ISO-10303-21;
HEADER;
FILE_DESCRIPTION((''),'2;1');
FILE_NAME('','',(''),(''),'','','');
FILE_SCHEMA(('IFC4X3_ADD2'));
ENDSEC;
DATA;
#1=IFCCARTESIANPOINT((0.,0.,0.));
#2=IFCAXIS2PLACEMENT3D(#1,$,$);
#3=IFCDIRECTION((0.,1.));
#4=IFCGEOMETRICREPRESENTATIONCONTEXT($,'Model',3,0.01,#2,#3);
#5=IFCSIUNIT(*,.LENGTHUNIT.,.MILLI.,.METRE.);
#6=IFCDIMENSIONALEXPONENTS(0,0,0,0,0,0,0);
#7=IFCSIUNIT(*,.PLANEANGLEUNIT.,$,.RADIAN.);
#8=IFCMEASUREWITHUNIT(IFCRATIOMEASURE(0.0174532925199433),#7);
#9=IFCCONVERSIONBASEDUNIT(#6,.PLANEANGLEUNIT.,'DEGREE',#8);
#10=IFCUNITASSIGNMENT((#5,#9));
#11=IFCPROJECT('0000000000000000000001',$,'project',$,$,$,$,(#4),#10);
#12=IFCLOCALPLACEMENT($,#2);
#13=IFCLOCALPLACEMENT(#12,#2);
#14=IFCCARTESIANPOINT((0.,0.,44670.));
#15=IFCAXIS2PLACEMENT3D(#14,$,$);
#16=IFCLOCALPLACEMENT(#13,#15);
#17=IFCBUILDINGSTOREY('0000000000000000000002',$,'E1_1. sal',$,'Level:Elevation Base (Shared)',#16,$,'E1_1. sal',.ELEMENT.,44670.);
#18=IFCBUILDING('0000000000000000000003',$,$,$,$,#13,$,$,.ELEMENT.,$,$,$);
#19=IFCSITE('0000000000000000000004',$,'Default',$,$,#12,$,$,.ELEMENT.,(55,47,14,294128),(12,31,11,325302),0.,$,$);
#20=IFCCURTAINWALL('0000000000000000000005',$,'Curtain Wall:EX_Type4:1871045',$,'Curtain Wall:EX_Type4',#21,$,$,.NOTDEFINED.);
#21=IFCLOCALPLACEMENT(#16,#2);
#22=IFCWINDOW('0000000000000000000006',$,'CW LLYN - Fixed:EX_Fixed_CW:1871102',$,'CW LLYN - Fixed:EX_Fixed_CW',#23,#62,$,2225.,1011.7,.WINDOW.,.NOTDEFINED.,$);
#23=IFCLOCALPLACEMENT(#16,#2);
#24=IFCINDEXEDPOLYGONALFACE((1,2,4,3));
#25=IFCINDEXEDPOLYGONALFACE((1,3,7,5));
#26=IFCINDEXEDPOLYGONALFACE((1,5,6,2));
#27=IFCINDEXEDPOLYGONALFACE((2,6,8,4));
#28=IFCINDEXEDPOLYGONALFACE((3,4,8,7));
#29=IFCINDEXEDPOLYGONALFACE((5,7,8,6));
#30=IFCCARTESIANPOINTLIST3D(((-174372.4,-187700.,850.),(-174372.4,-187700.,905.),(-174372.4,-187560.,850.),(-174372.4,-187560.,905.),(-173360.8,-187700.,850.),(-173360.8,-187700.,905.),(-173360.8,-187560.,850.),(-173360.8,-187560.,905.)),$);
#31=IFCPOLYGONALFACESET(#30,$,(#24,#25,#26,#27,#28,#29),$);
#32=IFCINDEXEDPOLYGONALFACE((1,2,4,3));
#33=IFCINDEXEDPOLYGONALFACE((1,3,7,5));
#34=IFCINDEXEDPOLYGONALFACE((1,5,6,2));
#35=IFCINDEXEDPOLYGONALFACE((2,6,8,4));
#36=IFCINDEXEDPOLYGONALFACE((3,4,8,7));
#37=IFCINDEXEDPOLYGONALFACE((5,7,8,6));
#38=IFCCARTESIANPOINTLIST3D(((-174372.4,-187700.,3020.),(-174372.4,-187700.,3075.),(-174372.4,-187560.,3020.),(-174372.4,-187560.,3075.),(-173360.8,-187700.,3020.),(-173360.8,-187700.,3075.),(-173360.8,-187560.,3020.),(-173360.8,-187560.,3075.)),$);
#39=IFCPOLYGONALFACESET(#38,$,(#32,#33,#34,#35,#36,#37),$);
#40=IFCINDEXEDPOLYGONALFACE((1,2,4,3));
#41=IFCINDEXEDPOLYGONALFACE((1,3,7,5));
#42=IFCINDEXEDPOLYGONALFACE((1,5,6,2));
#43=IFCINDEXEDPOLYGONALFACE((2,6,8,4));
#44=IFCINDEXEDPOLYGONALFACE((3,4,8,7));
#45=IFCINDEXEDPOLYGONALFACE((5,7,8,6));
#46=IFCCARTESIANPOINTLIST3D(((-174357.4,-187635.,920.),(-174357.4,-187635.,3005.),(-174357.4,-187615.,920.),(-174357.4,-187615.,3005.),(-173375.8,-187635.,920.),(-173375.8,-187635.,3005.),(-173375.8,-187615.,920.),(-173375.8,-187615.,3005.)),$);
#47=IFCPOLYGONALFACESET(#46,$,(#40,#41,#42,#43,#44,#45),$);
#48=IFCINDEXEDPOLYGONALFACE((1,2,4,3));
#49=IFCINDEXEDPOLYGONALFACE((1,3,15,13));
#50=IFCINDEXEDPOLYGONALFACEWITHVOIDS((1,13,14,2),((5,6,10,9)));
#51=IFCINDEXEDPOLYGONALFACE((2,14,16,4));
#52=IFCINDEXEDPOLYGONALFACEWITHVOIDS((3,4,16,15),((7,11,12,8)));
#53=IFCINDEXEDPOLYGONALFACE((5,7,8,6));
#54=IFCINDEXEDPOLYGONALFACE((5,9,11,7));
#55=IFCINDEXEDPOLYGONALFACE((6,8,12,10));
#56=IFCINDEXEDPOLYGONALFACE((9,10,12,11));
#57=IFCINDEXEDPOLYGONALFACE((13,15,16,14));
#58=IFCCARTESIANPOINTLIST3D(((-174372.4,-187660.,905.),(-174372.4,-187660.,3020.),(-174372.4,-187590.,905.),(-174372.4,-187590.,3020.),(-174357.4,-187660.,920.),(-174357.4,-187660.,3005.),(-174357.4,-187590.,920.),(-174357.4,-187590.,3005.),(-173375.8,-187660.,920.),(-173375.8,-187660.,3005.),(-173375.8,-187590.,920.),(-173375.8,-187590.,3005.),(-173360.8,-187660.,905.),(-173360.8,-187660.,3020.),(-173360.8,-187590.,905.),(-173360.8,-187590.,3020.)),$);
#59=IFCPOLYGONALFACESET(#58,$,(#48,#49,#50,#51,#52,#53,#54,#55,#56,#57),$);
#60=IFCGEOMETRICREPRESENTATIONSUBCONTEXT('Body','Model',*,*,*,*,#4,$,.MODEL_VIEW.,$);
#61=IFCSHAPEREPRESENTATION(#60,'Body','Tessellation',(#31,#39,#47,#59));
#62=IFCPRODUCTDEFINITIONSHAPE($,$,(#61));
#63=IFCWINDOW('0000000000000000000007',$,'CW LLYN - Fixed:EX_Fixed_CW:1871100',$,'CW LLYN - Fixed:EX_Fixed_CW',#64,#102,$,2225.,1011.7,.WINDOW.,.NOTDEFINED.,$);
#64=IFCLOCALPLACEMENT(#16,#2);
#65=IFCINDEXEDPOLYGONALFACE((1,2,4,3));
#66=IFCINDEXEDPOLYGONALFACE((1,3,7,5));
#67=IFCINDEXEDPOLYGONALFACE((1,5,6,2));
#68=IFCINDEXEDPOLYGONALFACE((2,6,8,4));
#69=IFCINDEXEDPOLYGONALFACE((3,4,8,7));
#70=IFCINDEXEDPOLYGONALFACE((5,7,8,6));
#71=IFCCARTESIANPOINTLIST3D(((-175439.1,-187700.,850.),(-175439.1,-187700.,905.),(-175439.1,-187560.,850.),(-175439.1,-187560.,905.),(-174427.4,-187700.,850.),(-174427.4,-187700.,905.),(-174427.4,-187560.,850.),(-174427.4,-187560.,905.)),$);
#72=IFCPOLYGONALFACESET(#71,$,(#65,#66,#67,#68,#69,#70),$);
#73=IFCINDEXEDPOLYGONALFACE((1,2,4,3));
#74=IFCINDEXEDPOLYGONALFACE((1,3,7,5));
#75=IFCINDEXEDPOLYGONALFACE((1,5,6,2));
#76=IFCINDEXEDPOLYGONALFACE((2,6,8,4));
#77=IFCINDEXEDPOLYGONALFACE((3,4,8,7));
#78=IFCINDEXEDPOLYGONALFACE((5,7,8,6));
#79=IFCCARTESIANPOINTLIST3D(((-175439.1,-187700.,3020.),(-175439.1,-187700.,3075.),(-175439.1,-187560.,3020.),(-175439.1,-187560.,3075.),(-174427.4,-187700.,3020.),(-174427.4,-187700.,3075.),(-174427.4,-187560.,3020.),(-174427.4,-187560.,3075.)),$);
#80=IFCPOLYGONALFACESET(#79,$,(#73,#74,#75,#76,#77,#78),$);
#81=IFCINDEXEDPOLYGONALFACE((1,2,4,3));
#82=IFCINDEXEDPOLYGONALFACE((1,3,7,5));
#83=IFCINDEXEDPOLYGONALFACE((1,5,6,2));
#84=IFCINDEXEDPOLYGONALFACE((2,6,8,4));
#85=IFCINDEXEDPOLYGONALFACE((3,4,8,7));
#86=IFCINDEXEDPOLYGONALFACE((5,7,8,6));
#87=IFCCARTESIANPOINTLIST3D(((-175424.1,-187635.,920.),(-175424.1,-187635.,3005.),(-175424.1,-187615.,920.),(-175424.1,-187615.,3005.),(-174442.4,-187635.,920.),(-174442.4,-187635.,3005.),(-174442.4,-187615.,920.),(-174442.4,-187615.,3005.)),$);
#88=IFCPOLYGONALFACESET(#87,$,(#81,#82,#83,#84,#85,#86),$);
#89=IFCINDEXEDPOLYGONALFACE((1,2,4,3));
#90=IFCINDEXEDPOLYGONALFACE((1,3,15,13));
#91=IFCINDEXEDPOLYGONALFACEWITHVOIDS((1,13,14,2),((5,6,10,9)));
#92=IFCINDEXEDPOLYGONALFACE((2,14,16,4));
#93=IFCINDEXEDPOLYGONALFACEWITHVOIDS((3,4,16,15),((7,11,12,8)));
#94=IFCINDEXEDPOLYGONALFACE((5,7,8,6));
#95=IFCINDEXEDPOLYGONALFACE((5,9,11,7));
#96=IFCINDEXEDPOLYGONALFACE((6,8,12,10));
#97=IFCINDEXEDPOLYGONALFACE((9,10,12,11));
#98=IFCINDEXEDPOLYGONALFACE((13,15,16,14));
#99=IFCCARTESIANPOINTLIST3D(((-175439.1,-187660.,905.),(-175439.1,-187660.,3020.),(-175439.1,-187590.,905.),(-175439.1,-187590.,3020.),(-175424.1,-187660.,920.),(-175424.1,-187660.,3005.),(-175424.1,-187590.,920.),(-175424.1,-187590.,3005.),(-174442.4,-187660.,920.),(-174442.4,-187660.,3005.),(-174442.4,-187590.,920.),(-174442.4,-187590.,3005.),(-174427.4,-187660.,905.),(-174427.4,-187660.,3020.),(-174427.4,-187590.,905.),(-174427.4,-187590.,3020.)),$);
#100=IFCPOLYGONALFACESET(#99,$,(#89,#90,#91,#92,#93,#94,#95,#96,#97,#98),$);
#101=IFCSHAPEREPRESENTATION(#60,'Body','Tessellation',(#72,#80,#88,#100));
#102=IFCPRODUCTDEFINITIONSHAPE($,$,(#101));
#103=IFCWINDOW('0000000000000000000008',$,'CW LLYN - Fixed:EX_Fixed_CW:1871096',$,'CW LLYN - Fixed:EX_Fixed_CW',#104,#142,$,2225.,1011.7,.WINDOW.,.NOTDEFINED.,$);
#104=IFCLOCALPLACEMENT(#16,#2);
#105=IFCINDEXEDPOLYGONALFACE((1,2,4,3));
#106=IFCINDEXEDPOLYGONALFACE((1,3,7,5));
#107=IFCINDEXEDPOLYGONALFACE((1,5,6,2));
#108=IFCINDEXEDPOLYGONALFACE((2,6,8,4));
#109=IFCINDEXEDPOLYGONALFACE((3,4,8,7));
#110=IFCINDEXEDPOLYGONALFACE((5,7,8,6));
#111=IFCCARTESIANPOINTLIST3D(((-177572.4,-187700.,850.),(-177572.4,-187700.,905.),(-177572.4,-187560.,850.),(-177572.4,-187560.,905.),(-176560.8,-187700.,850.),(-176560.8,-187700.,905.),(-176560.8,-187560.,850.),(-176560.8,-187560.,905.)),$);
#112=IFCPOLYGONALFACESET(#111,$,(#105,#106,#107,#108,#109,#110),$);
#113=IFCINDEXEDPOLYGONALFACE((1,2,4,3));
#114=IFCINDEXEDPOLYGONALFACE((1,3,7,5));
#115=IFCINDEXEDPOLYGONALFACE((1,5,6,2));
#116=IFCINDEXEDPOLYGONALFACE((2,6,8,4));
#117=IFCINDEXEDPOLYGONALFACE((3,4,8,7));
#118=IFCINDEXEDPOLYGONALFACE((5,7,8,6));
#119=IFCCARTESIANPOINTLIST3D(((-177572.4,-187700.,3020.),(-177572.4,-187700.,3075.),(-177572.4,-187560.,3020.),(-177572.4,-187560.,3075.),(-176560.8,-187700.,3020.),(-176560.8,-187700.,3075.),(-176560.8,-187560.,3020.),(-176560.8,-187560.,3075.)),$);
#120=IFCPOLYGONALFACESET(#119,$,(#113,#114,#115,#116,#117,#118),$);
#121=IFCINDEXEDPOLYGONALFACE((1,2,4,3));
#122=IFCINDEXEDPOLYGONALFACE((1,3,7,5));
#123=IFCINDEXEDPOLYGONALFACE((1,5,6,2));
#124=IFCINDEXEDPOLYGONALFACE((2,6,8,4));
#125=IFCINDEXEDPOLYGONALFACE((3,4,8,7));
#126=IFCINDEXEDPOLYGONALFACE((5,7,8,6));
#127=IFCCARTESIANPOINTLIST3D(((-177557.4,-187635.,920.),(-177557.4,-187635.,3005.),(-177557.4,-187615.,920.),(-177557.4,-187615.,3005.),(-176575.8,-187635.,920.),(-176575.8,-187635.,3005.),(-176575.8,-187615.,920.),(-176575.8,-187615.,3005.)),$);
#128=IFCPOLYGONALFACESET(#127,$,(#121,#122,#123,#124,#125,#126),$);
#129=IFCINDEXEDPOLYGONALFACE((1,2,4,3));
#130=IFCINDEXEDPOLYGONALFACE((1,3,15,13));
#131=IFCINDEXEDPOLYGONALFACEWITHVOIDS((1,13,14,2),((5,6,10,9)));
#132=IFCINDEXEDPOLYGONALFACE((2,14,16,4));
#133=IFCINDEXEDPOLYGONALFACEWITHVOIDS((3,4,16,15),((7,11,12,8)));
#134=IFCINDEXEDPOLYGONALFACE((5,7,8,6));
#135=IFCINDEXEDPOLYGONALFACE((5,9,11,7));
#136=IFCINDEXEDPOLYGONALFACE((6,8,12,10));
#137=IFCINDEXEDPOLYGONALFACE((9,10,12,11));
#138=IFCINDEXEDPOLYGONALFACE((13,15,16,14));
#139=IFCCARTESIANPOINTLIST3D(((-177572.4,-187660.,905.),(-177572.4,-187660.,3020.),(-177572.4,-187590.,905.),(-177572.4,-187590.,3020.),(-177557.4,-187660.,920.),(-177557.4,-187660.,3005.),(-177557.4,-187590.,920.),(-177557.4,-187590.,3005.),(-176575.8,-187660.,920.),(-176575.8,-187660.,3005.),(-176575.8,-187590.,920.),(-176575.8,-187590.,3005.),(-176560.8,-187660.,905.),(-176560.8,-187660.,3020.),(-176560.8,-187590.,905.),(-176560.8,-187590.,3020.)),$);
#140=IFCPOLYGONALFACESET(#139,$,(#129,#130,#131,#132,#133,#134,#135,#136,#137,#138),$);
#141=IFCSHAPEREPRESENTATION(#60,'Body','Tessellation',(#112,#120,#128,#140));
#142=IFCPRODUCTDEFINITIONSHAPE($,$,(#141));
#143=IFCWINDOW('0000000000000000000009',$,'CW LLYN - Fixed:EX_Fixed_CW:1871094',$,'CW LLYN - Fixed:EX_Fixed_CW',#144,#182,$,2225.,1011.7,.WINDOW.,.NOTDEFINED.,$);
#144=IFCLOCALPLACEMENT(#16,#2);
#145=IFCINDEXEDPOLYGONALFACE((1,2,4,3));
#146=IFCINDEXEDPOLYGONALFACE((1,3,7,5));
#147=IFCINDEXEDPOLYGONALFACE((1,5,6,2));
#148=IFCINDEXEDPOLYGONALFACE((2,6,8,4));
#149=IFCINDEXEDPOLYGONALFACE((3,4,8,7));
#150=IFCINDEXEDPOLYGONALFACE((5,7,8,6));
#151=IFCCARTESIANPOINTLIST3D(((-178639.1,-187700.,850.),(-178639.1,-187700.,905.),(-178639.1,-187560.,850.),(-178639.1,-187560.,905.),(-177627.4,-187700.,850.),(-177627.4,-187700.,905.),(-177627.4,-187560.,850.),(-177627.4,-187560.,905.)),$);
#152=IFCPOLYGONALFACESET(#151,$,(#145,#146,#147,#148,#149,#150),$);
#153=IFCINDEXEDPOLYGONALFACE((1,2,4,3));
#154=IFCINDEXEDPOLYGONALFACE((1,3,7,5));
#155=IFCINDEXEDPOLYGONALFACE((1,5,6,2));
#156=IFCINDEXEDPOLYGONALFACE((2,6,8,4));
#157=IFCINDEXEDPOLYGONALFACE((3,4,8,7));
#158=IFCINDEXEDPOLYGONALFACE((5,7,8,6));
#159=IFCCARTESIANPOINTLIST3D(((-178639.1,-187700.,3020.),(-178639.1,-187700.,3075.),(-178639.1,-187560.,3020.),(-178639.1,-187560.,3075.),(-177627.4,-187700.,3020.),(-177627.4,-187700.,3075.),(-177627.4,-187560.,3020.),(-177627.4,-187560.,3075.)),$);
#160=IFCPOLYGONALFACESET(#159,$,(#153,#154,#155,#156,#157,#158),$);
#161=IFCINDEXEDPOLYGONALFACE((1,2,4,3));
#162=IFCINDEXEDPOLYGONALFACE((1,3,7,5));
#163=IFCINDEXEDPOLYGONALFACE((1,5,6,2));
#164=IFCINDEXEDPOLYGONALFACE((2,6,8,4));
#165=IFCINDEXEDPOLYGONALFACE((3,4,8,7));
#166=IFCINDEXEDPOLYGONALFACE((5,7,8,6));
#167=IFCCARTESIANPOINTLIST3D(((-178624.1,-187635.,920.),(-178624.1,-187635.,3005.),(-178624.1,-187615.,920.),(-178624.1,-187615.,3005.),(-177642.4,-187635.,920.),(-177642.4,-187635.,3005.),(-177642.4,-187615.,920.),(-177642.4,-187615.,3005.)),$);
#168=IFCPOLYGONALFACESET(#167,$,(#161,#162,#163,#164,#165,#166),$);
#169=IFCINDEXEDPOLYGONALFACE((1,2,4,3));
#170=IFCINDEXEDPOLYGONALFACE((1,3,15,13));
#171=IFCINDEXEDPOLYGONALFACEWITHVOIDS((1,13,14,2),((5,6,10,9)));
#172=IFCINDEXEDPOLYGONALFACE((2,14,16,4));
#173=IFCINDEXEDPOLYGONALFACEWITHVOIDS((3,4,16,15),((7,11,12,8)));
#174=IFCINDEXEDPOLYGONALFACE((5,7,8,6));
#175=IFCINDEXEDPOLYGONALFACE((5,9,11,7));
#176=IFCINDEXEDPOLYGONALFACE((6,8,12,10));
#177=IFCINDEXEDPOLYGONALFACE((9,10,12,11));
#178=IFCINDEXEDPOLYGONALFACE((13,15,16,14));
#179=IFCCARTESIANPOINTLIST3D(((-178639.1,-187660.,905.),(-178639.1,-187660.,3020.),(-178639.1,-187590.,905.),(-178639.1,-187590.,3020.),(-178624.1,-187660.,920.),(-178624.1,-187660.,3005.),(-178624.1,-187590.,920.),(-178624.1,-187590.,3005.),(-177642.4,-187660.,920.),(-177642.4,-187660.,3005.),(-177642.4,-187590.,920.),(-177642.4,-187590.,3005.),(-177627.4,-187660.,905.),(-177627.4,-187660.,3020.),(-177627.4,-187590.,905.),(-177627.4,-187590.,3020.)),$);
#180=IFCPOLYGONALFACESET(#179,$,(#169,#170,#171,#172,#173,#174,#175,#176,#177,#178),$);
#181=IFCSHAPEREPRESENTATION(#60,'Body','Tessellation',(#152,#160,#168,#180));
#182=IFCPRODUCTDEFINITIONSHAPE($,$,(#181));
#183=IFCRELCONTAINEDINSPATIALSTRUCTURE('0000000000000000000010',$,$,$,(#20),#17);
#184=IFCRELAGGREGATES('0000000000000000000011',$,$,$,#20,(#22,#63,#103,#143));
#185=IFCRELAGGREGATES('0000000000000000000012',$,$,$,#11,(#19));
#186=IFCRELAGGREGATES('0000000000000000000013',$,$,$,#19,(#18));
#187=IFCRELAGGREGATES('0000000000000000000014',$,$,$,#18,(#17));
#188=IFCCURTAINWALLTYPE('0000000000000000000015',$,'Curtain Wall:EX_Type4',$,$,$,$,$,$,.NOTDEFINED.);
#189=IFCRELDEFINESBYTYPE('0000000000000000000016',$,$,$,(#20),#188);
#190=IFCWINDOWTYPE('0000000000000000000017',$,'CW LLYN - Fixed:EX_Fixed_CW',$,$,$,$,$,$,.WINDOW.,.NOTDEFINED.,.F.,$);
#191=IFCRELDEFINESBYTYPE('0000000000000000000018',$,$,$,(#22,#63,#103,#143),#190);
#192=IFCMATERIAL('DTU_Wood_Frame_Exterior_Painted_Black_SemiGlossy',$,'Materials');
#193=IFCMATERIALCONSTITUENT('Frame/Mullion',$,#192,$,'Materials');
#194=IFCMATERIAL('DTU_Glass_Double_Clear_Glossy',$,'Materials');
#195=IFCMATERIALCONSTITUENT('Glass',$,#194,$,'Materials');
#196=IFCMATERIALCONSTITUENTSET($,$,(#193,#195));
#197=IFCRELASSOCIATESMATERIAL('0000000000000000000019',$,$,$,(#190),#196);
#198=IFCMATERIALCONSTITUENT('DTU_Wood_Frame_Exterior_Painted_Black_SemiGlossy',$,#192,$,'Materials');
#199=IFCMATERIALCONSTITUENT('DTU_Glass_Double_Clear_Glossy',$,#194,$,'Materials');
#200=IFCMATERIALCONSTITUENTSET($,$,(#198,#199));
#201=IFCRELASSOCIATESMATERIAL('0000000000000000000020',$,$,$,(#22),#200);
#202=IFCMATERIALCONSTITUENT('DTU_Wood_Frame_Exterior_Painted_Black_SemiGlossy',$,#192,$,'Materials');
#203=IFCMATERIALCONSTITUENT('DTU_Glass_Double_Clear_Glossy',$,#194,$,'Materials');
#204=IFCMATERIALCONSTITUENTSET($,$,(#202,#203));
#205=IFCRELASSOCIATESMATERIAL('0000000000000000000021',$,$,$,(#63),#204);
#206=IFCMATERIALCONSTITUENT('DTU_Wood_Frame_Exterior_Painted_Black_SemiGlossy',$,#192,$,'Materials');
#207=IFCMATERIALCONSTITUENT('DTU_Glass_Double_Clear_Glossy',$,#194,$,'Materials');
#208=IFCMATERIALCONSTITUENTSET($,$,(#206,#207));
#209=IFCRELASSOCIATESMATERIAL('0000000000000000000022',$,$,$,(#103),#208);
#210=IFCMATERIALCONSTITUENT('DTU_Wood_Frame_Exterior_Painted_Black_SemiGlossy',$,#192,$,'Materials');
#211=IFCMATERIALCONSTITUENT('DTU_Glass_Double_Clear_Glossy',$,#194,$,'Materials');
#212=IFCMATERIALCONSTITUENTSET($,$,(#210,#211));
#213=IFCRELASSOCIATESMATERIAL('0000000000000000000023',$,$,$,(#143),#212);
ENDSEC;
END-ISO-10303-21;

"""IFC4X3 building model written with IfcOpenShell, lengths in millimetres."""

from ifc_helpers import new_model, entity, si_unit, converted_unit, direction, frame, frame_2d, origin, origin_2d_with_axis, place, context, subcontext, project, spatial, polyline, rectangle, outline, extrude, source, transform, mapped, material, constituent, constituent_set, type_object, type_shapes, element, aggregate, save


model = new_model("IFC4X3")

# Units and contexts
model_context = context("Model", 3, precision=0.01, world=origin(), true_north=direction((0.0, 1.0)))
body_context = subcontext(model_context, "Body", "Model", "MODEL_VIEW")
ifc_project = project(units=[si_unit("LENGTHUNIT", "METRE", prefix="MILLI"), converted_unit("PLANEANGLEUNIT", "DEGREE", entity("IfcRatioMeasure", 0.0174532925199433), si_unit("PLANEANGLEUNIT", "RADIAN"), dimensions=[0, 0, 0, 0, 0, 0, 0])], contexts=[model_context])

# Site, building, storey
site_placement = place(None, origin())
site = spatial("IfcSite", under=ifc_project, at=site_placement, Name="Default", CompositionType="ELEMENT", RefLatitude=(55, 47, 14, 294128), RefLongitude=(12, 31, 11, 325302), RefElevation=0.0)
building_placement = place(site_placement, origin())
building = spatial("IfcBuilding", under=site, at=building_placement, CompositionType="ELEMENT")
storey_placement = place(building_placement, frame((0.0, 0.0, 44670.0)))
storey = spatial("IfcBuildingStorey", under=building, at=storey_placement, Name="E1_1. sal", ObjectType="Level:Elevation Base (Shared)", LongName="E1_1. sal", CompositionType="ELEMENT", Elevation=44670.0)

# Curtain wall
curtain_wall_type_1 = type_object("IfcCurtainWallType", Name="Curtain Wall:EX_Type4", PredefinedType="NOTDEFINED")
curtain_wall_1_placement = place(storey_placement, frame((0.0, 0.0, -44670.0)))
curtain_wall_1 = element("IfcCurtainWall", 1, at=curtain_wall_1_placement, inside=storey, type_object=curtain_wall_type_1, Name="Curtain Wall:EX_Type4:1871045", ObjectType="Curtain Wall:EX_Type4", PredefinedType="NOTDEFINED")

# Windows
ifc_material_1 = material(Name="DTU_Wood_Frame_Exterior_Painted_Black_SemiGlossy", Category="Materials")
ifc_constituent_1 = constituent(ifc_material_1, Name="DTU_Wood_Frame_Exterior_Painted_Black_SemiGlossy", Category="Materials")
ifc_material_2 = material(Name="DTU_Glass_Double_Clear_Glossy", Category="Materials")
ifc_constituent_2 = constituent(ifc_material_2, Name="DTU_Glass_Double_Clear_Glossy", Category="Materials")
ifc_constituent_set_1 = constituent_set(constituents=[ifc_constituent_1, ifc_constituent_2])
ifc_constituent_3 = constituent(ifc_material_1, Name="Frame/Mullion", Category="Materials")
ifc_constituent_4 = constituent(ifc_material_2, Name="Glass", Category="Materials")
ifc_constituent_set_2 = constituent_set(constituents=[ifc_constituent_3, ifc_constituent_4])
window_type_1 = type_object("IfcWindowType", Name="CW LLYN - Fixed:EX_Fixed_CW", ParameterTakesPrecedence=False, PartitioningType="NOTDEFINED", PredefinedType="WINDOW", material=ifc_constituent_set_2)
shared_shape_1 = source(origin(), body_context, "Body", "SweptSolid", [
    extrude(rectangle(XDim=140.0, YDim=1011.7, at=origin_2d_with_axis()), frame((0.0, -130.0, 0.0), z_axis=(0.0, 0.0, 1.0), x_axis=(0.0, -1.0, 0.0)), (0.0, 0.0, 1.0), 55.0),
    extrude(rectangle(XDim=140.0, YDim=1011.7, at=frame_2d((0.0, 0.0), x_axis=(1.0, 0.0))), frame((0.0, -130.0, 2170.0), z_axis=(0.0, 0.0, 1.0), x_axis=(0.0, -1.0, 0.0)), (0.0, 0.0, 1.0), 55.0),
    extrude(rectangle(XDim=981.7, YDim=20.0, at=frame_2d((0.0, 0.0), x_axis=(1.0, 0.0))), frame((0.0, -125.0, 70.0), z_axis=(0.0, 0.0, 1.0), x_axis=(-1.0, 0.0, 0.0)), (0.0, 0.0, 1.0), 2085.0),
    extrude(outline(polyline([(-1057.5, -505.8), (1057.5, -505.8), (1057.5, 505.8), (-1057.5, 505.8), (-1057.5, -505.8)]), holes=[polyline([(-1042.5, 490.8), (1042.5, 490.8), (1042.5, -490.8), (-1042.5, -490.8), (-1042.5, 490.8)])]), frame((0.0, -90.0, 1112.5), z_axis=(0.0, -1.0, 0.0), x_axis=(0.0, 0.0, 1.0)), (0.0, 0.0, 1.0), 70.0),
])
type_shapes(window_type_1, [shared_shape_1])
window_1_placement = place(curtain_wall_1_placement, frame((-173866.6, -187500.0, 45520.0)))
window_1 = element("IfcWindow", 2, at=window_1_placement, type_object=window_type_1, material=ifc_constituent_set_1, Name="CW LLYN - Fixed:EX_Fixed_CW:1871102", ObjectType="CW LLYN - Fixed:EX_Fixed_CW", OverallHeight=2225.0, OverallWidth=1011.7, PartitioningType="NOTDEFINED", PredefinedType="WINDOW", context=body_context, shape_type="MappedRepresentation", body=[
    mapped(shared_shape_1, transform((0.0, 0.0, 0.0), scale=1.0)),
])
ifc_constituent_5 = constituent(ifc_material_1, Name="DTU_Wood_Frame_Exterior_Painted_Black_SemiGlossy", Category="Materials")
ifc_constituent_6 = constituent(ifc_material_2, Name="DTU_Glass_Double_Clear_Glossy", Category="Materials")
ifc_constituent_set_3 = constituent_set(constituents=[ifc_constituent_5, ifc_constituent_6])
window_2_placement = place(curtain_wall_1_placement, frame((-174933.3, -187500.0, 45520.0)))
window_2 = element("IfcWindow", 3, at=window_2_placement, type_object=window_type_1, material=ifc_constituent_set_3, Name="CW LLYN - Fixed:EX_Fixed_CW:1871100", ObjectType="CW LLYN - Fixed:EX_Fixed_CW", OverallHeight=2225.0, OverallWidth=1011.7, PartitioningType="NOTDEFINED", PredefinedType="WINDOW", context=body_context, shape_type="MappedRepresentation", body=[
    mapped(shared_shape_1, transform((0.0, 0.0, 0.0), scale=1.0)),
])
ifc_constituent_7 = constituent(ifc_material_1, Name="DTU_Wood_Frame_Exterior_Painted_Black_SemiGlossy", Category="Materials")
ifc_constituent_8 = constituent(ifc_material_2, Name="DTU_Glass_Double_Clear_Glossy", Category="Materials")
ifc_constituent_set_4 = constituent_set(constituents=[ifc_constituent_7, ifc_constituent_8])
window_3_placement = place(curtain_wall_1_placement, frame((-177066.6, -187500.0, 45520.0)))
window_3 = element("IfcWindow", 4, at=window_3_placement, type_object=window_type_1, material=ifc_constituent_set_4, Name="CW LLYN - Fixed:EX_Fixed_CW:1871096", ObjectType="CW LLYN - Fixed:EX_Fixed_CW", OverallHeight=2225.0, OverallWidth=1011.7, PartitioningType="NOTDEFINED", PredefinedType="WINDOW", context=body_context, shape_type="MappedRepresentation", body=[
    mapped(shared_shape_1, transform((0.0, 0.0, 0.0), scale=1.0)),
])
ifc_constituent_9 = constituent(ifc_material_1, Name="DTU_Wood_Frame_Exterior_Painted_Black_SemiGlossy", Category="Materials")
ifc_constituent_10 = constituent(ifc_material_2, Name="DTU_Glass_Double_Clear_Glossy", Category="Materials")
ifc_constituent_set_5 = constituent_set(constituents=[ifc_constituent_9, ifc_constituent_10])
window_4_placement = place(curtain_wall_1_placement, frame((-178133.3, -187500.0, 45520.0)))
window_4 = element("IfcWindow", 5, at=window_4_placement, type_object=window_type_1, material=ifc_constituent_set_5, Name="CW LLYN - Fixed:EX_Fixed_CW:1871094", ObjectType="CW LLYN - Fixed:EX_Fixed_CW", OverallHeight=2225.0, OverallWidth=1011.7, PartitioningType="NOTDEFINED", PredefinedType="WINDOW", context=body_context, shape_type="MappedRepresentation", body=[
    mapped(shared_shape_1, transform((0.0, 0.0, 0.0), scale=1.0)),
])

aggregate(curtain_wall_1, [window_1, window_2, window_3, window_4])

save(model, "model.ifc")
